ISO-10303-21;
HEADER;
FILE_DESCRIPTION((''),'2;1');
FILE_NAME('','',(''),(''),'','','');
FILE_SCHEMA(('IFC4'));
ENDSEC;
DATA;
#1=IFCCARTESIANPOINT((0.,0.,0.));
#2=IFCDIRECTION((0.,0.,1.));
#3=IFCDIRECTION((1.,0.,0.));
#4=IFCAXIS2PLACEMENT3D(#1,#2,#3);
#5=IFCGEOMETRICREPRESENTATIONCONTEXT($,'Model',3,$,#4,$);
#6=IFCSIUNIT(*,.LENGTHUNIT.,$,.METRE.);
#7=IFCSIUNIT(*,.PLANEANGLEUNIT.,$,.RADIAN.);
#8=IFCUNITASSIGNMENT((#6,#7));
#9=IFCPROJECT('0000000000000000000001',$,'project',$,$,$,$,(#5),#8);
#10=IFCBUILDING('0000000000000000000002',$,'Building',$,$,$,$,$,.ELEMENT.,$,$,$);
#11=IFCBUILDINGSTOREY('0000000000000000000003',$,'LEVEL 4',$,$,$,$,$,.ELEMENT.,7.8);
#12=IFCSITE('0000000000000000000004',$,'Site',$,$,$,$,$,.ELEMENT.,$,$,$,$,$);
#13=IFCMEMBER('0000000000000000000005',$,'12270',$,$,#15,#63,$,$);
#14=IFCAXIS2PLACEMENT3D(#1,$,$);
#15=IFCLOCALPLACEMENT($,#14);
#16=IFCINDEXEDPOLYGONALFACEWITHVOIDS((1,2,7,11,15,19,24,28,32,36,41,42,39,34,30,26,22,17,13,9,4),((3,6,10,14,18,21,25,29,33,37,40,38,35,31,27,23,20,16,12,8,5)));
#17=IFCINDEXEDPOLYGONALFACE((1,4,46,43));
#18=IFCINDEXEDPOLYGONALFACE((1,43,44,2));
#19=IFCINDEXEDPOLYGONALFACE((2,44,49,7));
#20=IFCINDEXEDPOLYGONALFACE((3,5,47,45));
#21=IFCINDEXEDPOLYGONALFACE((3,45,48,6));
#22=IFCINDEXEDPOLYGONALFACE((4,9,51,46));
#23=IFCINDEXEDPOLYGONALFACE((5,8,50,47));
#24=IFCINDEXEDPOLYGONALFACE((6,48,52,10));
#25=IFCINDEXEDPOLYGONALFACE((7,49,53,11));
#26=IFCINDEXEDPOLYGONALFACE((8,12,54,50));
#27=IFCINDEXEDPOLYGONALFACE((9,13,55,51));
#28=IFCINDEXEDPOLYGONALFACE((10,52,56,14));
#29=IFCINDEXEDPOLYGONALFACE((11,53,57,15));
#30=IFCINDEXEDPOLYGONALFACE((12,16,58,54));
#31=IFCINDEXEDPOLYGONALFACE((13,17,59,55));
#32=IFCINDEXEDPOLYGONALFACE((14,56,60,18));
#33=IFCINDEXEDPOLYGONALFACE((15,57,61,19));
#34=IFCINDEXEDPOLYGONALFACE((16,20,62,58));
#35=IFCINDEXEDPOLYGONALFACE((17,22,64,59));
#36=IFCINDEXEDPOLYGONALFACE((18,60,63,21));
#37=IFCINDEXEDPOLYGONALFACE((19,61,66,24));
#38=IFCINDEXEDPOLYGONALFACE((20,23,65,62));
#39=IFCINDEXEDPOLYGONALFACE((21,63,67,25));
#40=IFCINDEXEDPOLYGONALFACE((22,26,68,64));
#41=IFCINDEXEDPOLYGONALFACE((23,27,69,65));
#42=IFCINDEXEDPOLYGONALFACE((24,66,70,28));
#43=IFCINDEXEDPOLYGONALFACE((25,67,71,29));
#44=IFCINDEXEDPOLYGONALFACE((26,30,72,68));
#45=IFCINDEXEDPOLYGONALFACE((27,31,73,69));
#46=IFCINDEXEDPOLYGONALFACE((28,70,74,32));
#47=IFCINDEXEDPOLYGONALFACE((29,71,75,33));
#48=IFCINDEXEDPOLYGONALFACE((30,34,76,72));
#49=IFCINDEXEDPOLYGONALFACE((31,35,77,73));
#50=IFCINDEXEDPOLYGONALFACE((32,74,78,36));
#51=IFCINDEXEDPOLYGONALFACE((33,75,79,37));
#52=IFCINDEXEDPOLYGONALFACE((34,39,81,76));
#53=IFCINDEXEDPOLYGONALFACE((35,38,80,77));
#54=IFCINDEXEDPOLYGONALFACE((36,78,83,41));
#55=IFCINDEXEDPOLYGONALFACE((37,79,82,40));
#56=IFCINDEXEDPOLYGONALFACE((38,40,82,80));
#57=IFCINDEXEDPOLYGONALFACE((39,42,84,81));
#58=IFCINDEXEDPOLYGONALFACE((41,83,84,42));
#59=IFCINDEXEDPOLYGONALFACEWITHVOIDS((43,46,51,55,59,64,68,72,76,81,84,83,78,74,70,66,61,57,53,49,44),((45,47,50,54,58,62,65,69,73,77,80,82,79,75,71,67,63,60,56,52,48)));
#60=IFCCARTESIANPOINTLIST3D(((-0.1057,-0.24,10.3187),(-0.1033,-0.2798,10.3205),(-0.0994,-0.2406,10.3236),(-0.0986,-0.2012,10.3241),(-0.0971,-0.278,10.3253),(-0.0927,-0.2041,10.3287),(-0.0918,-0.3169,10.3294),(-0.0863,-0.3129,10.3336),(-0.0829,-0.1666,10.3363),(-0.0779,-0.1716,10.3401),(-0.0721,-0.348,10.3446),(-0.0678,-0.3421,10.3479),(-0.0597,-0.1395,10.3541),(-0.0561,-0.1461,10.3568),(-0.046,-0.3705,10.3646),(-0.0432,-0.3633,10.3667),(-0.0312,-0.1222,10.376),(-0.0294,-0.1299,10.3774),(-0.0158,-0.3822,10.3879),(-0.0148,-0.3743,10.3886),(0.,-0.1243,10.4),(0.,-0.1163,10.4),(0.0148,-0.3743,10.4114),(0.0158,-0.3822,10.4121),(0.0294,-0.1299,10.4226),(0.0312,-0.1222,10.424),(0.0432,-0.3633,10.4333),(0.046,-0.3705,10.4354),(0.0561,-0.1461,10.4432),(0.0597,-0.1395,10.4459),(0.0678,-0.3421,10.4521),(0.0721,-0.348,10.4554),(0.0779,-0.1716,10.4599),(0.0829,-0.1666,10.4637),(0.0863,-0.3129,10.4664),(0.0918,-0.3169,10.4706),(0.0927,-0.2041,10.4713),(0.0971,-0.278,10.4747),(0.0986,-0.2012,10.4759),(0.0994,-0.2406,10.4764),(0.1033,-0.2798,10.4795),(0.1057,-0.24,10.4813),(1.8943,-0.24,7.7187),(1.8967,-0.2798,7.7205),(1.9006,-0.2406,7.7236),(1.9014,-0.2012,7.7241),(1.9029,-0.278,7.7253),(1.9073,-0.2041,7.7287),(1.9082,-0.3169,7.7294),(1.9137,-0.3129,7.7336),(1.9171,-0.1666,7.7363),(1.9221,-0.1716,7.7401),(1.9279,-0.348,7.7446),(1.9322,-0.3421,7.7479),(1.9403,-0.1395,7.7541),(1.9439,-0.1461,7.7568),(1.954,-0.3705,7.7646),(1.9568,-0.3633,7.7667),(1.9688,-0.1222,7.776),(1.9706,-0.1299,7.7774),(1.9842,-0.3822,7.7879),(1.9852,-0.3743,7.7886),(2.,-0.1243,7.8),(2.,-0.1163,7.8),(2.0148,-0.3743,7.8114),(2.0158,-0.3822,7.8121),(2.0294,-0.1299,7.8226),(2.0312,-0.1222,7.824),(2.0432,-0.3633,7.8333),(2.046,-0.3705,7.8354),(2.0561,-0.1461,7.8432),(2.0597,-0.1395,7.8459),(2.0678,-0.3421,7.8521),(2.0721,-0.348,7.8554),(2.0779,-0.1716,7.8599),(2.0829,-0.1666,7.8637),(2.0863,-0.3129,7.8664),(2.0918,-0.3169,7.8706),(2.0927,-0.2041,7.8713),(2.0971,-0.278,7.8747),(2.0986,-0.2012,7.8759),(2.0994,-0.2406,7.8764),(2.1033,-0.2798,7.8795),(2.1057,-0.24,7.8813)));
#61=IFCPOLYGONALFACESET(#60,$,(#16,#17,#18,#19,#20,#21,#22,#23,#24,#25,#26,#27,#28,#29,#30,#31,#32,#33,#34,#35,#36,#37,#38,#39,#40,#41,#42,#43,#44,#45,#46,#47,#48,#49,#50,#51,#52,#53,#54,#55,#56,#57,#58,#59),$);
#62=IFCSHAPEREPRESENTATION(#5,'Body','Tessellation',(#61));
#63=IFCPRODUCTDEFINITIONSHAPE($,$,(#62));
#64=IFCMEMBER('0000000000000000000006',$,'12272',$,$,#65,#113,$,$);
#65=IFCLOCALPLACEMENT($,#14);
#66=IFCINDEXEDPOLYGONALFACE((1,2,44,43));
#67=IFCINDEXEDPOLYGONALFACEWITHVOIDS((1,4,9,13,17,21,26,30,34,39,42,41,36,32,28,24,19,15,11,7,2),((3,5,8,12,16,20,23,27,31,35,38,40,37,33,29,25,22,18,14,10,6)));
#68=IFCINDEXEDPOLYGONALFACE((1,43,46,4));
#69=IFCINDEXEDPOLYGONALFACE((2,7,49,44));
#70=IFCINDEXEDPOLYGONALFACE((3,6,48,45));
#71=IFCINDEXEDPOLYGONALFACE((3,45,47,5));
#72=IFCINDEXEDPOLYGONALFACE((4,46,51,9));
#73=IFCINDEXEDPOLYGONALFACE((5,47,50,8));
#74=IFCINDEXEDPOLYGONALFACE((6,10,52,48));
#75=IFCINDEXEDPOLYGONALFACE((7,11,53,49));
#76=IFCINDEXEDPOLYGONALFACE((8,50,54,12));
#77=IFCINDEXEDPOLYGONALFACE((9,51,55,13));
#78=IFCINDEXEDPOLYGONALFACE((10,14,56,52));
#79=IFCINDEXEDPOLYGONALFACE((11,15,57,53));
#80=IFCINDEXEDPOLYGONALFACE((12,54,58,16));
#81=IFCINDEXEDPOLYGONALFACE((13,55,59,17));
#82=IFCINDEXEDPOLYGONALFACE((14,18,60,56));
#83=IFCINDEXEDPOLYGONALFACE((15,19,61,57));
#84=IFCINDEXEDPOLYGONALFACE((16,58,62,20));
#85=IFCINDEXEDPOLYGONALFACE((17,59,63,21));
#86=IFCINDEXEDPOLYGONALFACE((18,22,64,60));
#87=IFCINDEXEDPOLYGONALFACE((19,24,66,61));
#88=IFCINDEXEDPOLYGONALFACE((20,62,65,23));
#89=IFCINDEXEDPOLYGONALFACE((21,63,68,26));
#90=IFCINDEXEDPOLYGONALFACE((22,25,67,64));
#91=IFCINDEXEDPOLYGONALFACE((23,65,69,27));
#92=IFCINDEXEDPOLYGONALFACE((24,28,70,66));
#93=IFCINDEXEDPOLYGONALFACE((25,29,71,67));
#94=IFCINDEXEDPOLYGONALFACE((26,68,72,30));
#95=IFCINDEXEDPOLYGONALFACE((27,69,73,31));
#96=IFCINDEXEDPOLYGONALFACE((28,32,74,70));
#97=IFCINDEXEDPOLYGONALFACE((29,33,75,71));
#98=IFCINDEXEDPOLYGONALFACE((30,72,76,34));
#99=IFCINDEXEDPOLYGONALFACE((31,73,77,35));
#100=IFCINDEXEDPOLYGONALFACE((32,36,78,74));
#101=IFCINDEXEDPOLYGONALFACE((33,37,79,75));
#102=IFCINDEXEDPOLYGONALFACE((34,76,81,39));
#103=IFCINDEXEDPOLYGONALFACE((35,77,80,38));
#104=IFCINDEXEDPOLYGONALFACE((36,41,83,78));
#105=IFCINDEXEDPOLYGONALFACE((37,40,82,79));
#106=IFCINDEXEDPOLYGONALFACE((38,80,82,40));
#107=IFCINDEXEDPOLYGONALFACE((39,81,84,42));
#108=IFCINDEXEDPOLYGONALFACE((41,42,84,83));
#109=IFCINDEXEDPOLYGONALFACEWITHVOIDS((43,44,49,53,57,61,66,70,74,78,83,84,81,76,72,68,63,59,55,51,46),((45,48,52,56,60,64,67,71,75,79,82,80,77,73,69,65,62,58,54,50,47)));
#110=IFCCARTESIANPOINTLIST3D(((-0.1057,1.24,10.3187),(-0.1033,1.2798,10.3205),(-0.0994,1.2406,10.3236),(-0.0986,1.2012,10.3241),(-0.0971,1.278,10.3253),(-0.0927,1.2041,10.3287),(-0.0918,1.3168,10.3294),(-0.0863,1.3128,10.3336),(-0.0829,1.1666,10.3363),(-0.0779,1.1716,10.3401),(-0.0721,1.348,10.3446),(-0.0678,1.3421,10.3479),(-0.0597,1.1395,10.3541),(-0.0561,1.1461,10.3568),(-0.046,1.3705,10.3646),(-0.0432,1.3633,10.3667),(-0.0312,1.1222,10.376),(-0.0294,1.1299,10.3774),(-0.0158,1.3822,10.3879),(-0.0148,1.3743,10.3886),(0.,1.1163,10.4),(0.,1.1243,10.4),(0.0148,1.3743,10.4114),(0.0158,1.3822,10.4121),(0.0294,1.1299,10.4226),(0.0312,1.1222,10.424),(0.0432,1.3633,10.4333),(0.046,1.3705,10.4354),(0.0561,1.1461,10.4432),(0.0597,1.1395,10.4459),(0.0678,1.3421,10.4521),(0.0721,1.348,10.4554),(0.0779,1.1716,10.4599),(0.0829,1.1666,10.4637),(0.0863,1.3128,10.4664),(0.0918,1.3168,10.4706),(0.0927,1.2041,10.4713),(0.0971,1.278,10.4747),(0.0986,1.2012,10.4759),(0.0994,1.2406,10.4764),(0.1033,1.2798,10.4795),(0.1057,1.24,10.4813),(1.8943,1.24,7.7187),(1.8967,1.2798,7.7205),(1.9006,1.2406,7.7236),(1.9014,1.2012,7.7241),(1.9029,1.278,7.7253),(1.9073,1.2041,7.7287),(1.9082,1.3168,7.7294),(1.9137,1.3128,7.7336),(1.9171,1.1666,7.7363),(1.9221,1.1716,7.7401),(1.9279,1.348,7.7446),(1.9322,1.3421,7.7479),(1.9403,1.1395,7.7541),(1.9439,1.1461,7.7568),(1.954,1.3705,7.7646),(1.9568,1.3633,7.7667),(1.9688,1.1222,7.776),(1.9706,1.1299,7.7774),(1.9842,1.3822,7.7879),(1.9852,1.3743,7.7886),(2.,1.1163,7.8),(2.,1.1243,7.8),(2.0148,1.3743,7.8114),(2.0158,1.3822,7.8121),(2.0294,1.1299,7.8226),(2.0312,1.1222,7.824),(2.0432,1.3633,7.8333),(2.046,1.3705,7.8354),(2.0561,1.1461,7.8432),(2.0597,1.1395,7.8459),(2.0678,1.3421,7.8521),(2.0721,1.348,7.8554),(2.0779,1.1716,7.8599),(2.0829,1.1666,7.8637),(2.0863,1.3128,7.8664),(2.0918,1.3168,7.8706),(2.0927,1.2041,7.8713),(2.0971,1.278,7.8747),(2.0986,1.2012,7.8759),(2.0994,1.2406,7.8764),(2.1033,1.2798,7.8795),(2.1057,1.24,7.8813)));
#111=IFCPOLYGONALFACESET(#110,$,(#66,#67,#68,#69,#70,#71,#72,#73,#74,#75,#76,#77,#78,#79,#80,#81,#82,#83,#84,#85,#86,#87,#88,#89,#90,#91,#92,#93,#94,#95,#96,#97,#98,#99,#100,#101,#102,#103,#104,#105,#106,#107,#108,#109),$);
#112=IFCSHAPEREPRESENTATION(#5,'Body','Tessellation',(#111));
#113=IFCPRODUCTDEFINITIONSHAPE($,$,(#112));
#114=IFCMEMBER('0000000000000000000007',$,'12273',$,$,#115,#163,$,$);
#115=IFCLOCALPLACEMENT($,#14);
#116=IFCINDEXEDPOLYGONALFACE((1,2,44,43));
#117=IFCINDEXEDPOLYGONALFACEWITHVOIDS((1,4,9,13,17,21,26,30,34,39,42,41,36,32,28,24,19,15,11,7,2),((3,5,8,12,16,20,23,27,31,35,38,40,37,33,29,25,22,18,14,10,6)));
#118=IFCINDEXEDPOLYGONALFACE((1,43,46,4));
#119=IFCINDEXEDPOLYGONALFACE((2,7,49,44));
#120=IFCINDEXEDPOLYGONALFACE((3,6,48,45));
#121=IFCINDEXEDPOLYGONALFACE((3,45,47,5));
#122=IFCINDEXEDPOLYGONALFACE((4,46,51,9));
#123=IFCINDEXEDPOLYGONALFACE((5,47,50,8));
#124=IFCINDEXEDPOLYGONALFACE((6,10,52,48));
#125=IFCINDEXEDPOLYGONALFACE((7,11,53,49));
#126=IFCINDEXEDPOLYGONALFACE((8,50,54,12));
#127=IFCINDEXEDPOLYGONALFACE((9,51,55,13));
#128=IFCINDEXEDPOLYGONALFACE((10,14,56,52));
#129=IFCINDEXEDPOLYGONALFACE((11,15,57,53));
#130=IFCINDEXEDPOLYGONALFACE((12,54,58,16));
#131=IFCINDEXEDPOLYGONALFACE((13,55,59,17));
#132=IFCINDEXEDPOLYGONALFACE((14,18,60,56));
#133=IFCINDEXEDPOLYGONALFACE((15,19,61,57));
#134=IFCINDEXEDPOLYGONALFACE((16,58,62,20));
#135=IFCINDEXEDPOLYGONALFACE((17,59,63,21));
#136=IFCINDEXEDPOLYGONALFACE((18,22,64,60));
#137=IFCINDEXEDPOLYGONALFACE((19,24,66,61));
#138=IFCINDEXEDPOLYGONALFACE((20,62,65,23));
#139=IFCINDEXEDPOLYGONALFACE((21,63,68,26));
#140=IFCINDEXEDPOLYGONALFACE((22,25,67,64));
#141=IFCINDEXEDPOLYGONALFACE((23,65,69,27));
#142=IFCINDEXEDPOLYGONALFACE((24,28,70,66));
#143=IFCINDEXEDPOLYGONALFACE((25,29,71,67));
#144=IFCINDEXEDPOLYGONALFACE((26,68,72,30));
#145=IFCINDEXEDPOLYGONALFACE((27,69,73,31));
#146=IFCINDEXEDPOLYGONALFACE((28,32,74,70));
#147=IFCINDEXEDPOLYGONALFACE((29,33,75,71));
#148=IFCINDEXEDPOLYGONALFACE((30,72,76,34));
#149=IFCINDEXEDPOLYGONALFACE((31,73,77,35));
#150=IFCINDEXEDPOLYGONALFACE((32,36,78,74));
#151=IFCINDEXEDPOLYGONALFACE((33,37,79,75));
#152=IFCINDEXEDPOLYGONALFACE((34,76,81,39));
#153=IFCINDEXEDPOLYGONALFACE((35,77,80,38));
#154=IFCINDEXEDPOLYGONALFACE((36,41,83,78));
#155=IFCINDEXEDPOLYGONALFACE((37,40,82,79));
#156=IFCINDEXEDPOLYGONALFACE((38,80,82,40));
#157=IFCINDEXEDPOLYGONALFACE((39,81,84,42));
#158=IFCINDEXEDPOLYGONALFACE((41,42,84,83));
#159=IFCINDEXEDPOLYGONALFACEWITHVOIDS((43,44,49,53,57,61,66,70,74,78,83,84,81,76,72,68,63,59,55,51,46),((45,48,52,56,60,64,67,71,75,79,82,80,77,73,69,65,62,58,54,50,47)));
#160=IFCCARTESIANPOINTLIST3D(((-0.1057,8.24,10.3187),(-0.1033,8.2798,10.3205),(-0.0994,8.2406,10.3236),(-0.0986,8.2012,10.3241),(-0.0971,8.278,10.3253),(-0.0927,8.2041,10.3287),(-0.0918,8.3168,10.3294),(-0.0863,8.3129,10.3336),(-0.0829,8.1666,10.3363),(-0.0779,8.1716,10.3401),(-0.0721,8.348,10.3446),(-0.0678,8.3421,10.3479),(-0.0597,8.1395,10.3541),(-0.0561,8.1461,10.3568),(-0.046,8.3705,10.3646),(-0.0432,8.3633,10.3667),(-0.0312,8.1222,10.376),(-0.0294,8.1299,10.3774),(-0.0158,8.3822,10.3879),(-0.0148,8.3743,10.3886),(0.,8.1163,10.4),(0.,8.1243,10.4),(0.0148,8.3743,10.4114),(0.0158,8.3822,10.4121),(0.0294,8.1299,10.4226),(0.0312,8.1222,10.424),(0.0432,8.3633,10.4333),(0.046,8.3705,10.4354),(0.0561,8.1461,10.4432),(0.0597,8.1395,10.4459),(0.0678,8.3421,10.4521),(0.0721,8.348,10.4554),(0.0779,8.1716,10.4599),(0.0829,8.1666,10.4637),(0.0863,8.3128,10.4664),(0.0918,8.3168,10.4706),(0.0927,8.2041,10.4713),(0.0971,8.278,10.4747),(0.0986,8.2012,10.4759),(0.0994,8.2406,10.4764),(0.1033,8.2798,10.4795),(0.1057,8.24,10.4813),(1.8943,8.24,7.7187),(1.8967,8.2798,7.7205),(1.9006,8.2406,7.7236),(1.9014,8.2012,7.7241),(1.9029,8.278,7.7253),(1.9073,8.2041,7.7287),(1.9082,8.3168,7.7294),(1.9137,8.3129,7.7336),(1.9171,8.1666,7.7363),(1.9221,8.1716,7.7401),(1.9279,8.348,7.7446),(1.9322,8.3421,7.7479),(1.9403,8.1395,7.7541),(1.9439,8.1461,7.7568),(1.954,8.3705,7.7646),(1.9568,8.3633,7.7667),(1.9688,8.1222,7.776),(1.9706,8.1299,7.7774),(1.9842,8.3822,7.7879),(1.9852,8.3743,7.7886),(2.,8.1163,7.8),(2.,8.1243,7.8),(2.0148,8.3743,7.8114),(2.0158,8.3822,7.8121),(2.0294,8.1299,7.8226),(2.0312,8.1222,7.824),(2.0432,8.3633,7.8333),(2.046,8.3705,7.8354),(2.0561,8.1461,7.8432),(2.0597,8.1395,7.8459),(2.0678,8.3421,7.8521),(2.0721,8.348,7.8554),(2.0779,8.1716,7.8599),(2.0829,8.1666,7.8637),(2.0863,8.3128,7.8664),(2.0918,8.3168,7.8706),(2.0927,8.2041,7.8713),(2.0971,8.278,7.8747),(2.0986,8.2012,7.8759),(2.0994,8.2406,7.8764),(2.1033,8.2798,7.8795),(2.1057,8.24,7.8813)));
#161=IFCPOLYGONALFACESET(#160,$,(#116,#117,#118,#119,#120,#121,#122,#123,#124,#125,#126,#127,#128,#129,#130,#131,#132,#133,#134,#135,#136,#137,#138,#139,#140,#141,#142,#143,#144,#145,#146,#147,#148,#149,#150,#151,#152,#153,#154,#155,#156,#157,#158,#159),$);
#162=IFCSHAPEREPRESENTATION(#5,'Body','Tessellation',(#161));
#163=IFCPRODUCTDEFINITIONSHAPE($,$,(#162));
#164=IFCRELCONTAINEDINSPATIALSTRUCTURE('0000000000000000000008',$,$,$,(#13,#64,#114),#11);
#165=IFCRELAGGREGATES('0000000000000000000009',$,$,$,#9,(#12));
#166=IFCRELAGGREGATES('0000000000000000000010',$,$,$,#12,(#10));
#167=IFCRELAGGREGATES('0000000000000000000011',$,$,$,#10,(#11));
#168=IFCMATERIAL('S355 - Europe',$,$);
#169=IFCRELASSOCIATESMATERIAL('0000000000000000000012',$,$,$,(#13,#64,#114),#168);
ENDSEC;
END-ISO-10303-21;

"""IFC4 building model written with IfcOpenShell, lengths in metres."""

from ifc_helpers import new_model, si_unit, frame, origin_with_axes, origin_2d_with_axis, place, context, project, spatial, hollow_circle, extrude, material, material_profile, profile_set, profile_usage, element, save


model = new_model("IFC4")

# Units and contexts
model_context = context("Model", 3, world=origin_with_axes())
ifc_project = project(units=[si_unit("LENGTHUNIT", "METRE"), si_unit("PLANEANGLEUNIT", "RADIAN")], contexts=[model_context])

# Site, building, storey
site = spatial("IfcSite", under=ifc_project, Name="Site", CompositionType="ELEMENT")
building = spatial("IfcBuilding", under=site, Name="Building", CompositionType="ELEMENT")
storey = spatial("IfcBuildingStorey", under=building, Name="LEVEL 4", CompositionType="ELEMENT", Elevation=7.8)

# Shared definitions
ifc_material = material(Name="S355 - Europe")

# Members
ifc_material_profile_1 = material_profile(ifc_material, hollow_circle(Radius=0.1337, WallThickness=0.008, at=origin_2d_with_axis()))
ifc_profile_set_1 = profile_set([ifc_material_profile_1])
ifc_profile_usage_1 = profile_usage(ifc_profile_set_1, cardinal=10)
member_1_placement = place(None, frame((0.0, -0.25, 10.4), z_axis=(0.609711, 0.0, -0.792624), x_axis=(0.0, 1.0, 0.0)))
element("IfcMember", 1, at=member_1_placement, inside=storey, material=ifc_profile_usage_1, Name="12270", context=model_context, shape_type="SweptSolid", body=[
    extrude(hollow_circle(Radius=0.1337, WallThickness=0.008, at=origin_2d_with_axis()), origin_with_axes(), (0.0, 0.0, 1.0), 3.2802),
])
ifc_material_profile_2 = material_profile(ifc_material, hollow_circle(Radius=0.1337, WallThickness=0.008, at=origin_2d_with_axis()))
ifc_profile_set_2 = profile_set([ifc_material_profile_2])
ifc_profile_usage_2 = profile_usage(ifc_profile_set_2, cardinal=10)
member_2_placement = place(None, frame((2.0, 1.25, 7.8), z_axis=(-0.609711, 0.0, 0.792624), x_axis=(0.0, -1.0, 0.0)))
element("IfcMember", 2, at=member_2_placement, inside=storey, material=ifc_profile_usage_2, Name="12272", context=model_context, shape_type="SweptSolid", body=[
    extrude(hollow_circle(Radius=0.1337, WallThickness=0.008, at=origin_2d_with_axis()), origin_with_axes(), (0.0, 0.0, 1.0), 3.2802),
])
ifc_material_profile_3 = material_profile(ifc_material, hollow_circle(Radius=0.1337, WallThickness=0.008, at=origin_2d_with_axis()))
ifc_profile_set_3 = profile_set([ifc_material_profile_3])
ifc_profile_usage_3 = profile_usage(ifc_profile_set_3, cardinal=10)
member_3_placement = place(None, frame((2.0, 8.25, 7.8), z_axis=(-0.609711, 0.0, 0.792624), x_axis=(0.0, -1.0, 0.0)))
element("IfcMember", 3, at=member_3_placement, inside=storey, material=ifc_profile_usage_3, Name="12273", context=model_context, shape_type="SweptSolid", body=[
    extrude(hollow_circle(Radius=0.1337, WallThickness=0.008, at=origin_2d_with_axis()), origin_with_axes(), (0.0, 0.0, 1.0), 3.2802),
])

save(model, "model.ifc")
